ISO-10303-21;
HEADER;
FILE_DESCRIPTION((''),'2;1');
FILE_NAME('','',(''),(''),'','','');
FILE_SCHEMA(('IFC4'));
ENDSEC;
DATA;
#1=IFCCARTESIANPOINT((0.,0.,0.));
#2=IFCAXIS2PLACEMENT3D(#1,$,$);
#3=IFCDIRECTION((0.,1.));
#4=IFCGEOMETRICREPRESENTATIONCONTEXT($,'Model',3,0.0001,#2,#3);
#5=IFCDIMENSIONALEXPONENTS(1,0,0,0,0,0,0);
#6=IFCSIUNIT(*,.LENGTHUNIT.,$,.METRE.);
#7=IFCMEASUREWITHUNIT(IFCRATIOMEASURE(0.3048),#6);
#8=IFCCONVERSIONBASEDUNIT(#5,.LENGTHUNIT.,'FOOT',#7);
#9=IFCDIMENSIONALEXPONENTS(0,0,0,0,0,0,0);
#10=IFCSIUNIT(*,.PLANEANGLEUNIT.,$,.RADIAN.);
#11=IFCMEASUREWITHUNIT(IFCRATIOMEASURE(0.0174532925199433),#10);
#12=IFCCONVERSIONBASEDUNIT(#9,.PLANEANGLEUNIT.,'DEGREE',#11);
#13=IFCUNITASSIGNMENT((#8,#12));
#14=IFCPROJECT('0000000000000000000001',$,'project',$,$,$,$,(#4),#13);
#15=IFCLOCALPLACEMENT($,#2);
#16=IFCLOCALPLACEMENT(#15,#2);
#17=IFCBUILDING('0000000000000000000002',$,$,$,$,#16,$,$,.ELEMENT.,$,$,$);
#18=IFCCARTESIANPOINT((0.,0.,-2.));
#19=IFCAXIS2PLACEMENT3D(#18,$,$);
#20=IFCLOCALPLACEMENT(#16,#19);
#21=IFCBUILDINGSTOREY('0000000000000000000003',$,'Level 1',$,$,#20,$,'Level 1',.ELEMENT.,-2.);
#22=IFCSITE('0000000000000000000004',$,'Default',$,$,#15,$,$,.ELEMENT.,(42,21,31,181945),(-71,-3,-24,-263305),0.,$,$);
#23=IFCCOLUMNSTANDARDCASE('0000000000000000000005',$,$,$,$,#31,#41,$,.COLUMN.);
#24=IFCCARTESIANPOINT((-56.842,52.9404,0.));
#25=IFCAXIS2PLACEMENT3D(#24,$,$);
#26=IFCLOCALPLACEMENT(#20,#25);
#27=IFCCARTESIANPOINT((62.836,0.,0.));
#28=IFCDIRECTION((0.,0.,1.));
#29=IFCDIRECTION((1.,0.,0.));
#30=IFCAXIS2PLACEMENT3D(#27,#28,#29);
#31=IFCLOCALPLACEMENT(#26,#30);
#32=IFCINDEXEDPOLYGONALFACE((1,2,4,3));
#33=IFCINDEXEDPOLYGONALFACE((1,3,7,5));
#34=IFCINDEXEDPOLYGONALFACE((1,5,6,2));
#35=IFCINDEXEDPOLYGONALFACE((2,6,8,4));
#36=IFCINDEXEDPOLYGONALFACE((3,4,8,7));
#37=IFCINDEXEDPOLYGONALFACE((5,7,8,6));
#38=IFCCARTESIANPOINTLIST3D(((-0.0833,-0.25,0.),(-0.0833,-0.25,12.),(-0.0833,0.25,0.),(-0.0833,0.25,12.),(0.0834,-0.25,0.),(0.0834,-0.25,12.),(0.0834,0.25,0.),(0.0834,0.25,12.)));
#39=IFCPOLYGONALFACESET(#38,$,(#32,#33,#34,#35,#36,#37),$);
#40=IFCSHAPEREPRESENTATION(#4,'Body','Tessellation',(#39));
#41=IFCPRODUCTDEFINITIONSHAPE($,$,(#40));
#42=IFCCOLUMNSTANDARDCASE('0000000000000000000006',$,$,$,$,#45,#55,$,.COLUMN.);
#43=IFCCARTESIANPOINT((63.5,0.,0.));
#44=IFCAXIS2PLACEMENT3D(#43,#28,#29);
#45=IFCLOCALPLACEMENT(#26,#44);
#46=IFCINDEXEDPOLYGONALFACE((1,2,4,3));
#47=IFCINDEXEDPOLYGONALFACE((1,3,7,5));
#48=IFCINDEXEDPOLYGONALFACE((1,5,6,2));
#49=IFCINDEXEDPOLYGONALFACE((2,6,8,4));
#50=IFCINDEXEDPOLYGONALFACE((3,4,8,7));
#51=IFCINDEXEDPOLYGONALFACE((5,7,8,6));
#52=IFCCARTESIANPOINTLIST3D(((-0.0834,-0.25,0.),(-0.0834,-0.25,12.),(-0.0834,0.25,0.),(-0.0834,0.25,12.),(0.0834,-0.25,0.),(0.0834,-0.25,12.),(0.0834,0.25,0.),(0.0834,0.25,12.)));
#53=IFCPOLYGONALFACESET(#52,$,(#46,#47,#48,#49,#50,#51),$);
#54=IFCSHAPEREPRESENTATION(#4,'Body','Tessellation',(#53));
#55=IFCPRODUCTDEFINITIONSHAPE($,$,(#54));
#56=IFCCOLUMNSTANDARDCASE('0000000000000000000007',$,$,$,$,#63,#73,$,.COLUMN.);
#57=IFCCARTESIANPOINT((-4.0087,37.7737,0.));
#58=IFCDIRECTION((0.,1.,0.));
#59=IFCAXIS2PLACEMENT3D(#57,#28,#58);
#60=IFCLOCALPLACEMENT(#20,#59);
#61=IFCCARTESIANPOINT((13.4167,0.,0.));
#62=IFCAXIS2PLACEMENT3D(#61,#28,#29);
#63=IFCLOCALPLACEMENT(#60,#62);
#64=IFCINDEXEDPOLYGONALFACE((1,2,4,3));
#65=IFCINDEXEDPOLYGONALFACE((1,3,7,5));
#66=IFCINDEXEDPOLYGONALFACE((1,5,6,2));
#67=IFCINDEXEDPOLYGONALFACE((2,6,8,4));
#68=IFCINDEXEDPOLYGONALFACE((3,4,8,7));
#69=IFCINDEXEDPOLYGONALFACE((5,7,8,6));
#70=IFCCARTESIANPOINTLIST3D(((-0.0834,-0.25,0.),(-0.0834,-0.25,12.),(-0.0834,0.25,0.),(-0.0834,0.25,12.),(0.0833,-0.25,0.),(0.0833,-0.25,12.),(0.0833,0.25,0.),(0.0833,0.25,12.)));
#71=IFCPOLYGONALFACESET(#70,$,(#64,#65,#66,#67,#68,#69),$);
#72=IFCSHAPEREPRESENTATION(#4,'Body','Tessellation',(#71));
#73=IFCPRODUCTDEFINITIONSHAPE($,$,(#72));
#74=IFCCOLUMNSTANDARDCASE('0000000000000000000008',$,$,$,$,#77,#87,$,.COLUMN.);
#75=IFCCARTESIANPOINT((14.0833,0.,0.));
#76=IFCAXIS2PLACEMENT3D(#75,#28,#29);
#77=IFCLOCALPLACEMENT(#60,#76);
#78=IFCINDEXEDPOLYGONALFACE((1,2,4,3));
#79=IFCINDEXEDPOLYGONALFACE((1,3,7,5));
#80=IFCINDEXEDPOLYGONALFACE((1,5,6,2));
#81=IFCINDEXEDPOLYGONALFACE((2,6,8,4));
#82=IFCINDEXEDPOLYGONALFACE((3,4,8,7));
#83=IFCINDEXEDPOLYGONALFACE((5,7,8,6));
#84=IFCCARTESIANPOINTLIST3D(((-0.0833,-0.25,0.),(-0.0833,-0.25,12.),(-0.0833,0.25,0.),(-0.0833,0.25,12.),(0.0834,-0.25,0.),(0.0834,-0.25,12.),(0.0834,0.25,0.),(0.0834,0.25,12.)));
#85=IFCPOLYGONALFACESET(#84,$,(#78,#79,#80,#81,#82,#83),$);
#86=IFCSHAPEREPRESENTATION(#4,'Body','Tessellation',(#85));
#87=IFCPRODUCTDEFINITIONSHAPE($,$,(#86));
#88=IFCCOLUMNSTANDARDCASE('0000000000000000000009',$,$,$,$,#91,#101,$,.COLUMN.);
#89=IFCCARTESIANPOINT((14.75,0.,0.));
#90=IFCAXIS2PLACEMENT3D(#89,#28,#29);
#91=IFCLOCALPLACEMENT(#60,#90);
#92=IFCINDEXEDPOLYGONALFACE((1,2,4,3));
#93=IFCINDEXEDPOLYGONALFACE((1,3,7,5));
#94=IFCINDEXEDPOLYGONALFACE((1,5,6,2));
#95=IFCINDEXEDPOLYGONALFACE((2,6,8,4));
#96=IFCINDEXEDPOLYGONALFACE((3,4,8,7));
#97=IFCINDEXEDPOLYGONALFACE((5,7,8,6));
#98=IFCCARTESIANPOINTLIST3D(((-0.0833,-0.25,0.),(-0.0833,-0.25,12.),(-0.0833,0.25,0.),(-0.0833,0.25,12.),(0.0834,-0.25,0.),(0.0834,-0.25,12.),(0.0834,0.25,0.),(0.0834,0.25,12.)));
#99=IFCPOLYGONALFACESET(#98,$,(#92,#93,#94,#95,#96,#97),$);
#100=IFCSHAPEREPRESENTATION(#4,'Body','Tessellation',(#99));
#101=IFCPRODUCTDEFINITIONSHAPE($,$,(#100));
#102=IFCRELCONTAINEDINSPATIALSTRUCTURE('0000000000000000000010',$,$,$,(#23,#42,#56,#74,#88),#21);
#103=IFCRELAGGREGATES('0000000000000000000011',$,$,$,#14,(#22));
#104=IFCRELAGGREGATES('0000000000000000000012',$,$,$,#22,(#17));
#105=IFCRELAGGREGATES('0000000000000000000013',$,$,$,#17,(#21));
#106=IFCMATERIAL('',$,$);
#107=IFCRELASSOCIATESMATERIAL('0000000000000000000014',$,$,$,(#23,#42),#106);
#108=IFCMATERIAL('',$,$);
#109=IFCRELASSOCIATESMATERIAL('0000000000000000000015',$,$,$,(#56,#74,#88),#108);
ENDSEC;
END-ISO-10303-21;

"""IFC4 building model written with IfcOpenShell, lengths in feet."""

from ifc_helpers import new_model, entity, si_unit, converted_unit, direction, frame, origin, place, context, project, spatial, rectangle, extrude, material, element, save


model = new_model("IFC4")

# Units and contexts
model_context = context("Model", 3, precision=0.0001, world=origin(), true_north=direction((0.0, 1.0)))
ifc_project = project(units=[converted_unit("LENGTHUNIT", "FOOT", entity("IfcRatioMeasure", 0.3048), si_unit("LENGTHUNIT", "METRE"), dimensions=[1, 0, 0, 0, 0, 0, 0]), converted_unit("PLANEANGLEUNIT", "DEGREE", entity("IfcRatioMeasure", 0.0174532925199433), si_unit("PLANEANGLEUNIT", "RADIAN"), dimensions=[0, 0, 0, 0, 0, 0, 0])], contexts=[model_context])

# Site, building, storey
site_placement = place(None, origin())
site = spatial("IfcSite", under=ifc_project, at=site_placement, Name="Default", CompositionType="ELEMENT", RefLatitude=(42, 21, 31, 181945), RefLongitude=(-71, -3, -24, -263305), RefElevation=0.0)
building_placement = place(site_placement, origin())
building = spatial("IfcBuilding", under=site, at=building_placement, CompositionType="ELEMENT")
storey_placement = place(building_placement, frame((0.0, 0.0, -2.0)))
storey = spatial("IfcBuildingStorey", under=building, at=storey_placement, Name="Level 1", LongName="Level 1", CompositionType="ELEMENT", Elevation=-2.0)

# Columns
ifc_material_1 = material(Name="")
placement_1 = place(storey_placement, frame((-56.842, 52.9404, 0.0)))
for number, where, z_axis, x_axis in (
    (1, (62.836, 0.0, 0.0), (0.0, 0.0, 1.0), (1.0, 0.0, 0.0)),
    (2, (63.5, 0.0, 0.0), (0.0, 0.0, 1.0), (1.0, 0.0, 0.0)),
):
    element("IfcColumnStandardCase", number, at=place(placement_1, frame(where, z_axis=z_axis, x_axis=x_axis)), inside=storey, material=ifc_material_1, PredefinedType="COLUMN", context=model_context, shape_type="SweptSolid", body=[
        extrude(rectangle(XDim=0.1667, YDim=0.5), origin(), (0.0, 0.0, 1.0), 12.0),
    ])
ifc_material_2 = material(Name="")
placement_2 = place(storey_placement, frame((-4.0087, 37.7737, 0.0), z_axis=(0.0, 0.0, 1.0), x_axis=(0.0, 1.0, 0.0)))
for number, where, z_axis, x_axis in (
    (3, (13.4167, 0.0, 0.0), (0.0, 0.0, 1.0), (1.0, 0.0, 0.0)),
    (4, (14.0833, 0.0, 0.0), (0.0, 0.0, 1.0), (1.0, 0.0, 0.0)),
    (5, (14.75, 0.0, 0.0), (0.0, 0.0, 1.0), (1.0, 0.0, 0.0)),
):
    element("IfcColumnStandardCase", number, at=place(placement_2, frame(where, z_axis=z_axis, x_axis=x_axis)), inside=storey, material=ifc_material_2, PredefinedType="COLUMN", context=model_context, shape_type="SweptSolid", body=[
        extrude(rectangle(XDim=0.1667, YDim=0.5), origin(), (0.0, 0.0, 1.0), 12.0),
    ])

save(model, "model.ifc")
